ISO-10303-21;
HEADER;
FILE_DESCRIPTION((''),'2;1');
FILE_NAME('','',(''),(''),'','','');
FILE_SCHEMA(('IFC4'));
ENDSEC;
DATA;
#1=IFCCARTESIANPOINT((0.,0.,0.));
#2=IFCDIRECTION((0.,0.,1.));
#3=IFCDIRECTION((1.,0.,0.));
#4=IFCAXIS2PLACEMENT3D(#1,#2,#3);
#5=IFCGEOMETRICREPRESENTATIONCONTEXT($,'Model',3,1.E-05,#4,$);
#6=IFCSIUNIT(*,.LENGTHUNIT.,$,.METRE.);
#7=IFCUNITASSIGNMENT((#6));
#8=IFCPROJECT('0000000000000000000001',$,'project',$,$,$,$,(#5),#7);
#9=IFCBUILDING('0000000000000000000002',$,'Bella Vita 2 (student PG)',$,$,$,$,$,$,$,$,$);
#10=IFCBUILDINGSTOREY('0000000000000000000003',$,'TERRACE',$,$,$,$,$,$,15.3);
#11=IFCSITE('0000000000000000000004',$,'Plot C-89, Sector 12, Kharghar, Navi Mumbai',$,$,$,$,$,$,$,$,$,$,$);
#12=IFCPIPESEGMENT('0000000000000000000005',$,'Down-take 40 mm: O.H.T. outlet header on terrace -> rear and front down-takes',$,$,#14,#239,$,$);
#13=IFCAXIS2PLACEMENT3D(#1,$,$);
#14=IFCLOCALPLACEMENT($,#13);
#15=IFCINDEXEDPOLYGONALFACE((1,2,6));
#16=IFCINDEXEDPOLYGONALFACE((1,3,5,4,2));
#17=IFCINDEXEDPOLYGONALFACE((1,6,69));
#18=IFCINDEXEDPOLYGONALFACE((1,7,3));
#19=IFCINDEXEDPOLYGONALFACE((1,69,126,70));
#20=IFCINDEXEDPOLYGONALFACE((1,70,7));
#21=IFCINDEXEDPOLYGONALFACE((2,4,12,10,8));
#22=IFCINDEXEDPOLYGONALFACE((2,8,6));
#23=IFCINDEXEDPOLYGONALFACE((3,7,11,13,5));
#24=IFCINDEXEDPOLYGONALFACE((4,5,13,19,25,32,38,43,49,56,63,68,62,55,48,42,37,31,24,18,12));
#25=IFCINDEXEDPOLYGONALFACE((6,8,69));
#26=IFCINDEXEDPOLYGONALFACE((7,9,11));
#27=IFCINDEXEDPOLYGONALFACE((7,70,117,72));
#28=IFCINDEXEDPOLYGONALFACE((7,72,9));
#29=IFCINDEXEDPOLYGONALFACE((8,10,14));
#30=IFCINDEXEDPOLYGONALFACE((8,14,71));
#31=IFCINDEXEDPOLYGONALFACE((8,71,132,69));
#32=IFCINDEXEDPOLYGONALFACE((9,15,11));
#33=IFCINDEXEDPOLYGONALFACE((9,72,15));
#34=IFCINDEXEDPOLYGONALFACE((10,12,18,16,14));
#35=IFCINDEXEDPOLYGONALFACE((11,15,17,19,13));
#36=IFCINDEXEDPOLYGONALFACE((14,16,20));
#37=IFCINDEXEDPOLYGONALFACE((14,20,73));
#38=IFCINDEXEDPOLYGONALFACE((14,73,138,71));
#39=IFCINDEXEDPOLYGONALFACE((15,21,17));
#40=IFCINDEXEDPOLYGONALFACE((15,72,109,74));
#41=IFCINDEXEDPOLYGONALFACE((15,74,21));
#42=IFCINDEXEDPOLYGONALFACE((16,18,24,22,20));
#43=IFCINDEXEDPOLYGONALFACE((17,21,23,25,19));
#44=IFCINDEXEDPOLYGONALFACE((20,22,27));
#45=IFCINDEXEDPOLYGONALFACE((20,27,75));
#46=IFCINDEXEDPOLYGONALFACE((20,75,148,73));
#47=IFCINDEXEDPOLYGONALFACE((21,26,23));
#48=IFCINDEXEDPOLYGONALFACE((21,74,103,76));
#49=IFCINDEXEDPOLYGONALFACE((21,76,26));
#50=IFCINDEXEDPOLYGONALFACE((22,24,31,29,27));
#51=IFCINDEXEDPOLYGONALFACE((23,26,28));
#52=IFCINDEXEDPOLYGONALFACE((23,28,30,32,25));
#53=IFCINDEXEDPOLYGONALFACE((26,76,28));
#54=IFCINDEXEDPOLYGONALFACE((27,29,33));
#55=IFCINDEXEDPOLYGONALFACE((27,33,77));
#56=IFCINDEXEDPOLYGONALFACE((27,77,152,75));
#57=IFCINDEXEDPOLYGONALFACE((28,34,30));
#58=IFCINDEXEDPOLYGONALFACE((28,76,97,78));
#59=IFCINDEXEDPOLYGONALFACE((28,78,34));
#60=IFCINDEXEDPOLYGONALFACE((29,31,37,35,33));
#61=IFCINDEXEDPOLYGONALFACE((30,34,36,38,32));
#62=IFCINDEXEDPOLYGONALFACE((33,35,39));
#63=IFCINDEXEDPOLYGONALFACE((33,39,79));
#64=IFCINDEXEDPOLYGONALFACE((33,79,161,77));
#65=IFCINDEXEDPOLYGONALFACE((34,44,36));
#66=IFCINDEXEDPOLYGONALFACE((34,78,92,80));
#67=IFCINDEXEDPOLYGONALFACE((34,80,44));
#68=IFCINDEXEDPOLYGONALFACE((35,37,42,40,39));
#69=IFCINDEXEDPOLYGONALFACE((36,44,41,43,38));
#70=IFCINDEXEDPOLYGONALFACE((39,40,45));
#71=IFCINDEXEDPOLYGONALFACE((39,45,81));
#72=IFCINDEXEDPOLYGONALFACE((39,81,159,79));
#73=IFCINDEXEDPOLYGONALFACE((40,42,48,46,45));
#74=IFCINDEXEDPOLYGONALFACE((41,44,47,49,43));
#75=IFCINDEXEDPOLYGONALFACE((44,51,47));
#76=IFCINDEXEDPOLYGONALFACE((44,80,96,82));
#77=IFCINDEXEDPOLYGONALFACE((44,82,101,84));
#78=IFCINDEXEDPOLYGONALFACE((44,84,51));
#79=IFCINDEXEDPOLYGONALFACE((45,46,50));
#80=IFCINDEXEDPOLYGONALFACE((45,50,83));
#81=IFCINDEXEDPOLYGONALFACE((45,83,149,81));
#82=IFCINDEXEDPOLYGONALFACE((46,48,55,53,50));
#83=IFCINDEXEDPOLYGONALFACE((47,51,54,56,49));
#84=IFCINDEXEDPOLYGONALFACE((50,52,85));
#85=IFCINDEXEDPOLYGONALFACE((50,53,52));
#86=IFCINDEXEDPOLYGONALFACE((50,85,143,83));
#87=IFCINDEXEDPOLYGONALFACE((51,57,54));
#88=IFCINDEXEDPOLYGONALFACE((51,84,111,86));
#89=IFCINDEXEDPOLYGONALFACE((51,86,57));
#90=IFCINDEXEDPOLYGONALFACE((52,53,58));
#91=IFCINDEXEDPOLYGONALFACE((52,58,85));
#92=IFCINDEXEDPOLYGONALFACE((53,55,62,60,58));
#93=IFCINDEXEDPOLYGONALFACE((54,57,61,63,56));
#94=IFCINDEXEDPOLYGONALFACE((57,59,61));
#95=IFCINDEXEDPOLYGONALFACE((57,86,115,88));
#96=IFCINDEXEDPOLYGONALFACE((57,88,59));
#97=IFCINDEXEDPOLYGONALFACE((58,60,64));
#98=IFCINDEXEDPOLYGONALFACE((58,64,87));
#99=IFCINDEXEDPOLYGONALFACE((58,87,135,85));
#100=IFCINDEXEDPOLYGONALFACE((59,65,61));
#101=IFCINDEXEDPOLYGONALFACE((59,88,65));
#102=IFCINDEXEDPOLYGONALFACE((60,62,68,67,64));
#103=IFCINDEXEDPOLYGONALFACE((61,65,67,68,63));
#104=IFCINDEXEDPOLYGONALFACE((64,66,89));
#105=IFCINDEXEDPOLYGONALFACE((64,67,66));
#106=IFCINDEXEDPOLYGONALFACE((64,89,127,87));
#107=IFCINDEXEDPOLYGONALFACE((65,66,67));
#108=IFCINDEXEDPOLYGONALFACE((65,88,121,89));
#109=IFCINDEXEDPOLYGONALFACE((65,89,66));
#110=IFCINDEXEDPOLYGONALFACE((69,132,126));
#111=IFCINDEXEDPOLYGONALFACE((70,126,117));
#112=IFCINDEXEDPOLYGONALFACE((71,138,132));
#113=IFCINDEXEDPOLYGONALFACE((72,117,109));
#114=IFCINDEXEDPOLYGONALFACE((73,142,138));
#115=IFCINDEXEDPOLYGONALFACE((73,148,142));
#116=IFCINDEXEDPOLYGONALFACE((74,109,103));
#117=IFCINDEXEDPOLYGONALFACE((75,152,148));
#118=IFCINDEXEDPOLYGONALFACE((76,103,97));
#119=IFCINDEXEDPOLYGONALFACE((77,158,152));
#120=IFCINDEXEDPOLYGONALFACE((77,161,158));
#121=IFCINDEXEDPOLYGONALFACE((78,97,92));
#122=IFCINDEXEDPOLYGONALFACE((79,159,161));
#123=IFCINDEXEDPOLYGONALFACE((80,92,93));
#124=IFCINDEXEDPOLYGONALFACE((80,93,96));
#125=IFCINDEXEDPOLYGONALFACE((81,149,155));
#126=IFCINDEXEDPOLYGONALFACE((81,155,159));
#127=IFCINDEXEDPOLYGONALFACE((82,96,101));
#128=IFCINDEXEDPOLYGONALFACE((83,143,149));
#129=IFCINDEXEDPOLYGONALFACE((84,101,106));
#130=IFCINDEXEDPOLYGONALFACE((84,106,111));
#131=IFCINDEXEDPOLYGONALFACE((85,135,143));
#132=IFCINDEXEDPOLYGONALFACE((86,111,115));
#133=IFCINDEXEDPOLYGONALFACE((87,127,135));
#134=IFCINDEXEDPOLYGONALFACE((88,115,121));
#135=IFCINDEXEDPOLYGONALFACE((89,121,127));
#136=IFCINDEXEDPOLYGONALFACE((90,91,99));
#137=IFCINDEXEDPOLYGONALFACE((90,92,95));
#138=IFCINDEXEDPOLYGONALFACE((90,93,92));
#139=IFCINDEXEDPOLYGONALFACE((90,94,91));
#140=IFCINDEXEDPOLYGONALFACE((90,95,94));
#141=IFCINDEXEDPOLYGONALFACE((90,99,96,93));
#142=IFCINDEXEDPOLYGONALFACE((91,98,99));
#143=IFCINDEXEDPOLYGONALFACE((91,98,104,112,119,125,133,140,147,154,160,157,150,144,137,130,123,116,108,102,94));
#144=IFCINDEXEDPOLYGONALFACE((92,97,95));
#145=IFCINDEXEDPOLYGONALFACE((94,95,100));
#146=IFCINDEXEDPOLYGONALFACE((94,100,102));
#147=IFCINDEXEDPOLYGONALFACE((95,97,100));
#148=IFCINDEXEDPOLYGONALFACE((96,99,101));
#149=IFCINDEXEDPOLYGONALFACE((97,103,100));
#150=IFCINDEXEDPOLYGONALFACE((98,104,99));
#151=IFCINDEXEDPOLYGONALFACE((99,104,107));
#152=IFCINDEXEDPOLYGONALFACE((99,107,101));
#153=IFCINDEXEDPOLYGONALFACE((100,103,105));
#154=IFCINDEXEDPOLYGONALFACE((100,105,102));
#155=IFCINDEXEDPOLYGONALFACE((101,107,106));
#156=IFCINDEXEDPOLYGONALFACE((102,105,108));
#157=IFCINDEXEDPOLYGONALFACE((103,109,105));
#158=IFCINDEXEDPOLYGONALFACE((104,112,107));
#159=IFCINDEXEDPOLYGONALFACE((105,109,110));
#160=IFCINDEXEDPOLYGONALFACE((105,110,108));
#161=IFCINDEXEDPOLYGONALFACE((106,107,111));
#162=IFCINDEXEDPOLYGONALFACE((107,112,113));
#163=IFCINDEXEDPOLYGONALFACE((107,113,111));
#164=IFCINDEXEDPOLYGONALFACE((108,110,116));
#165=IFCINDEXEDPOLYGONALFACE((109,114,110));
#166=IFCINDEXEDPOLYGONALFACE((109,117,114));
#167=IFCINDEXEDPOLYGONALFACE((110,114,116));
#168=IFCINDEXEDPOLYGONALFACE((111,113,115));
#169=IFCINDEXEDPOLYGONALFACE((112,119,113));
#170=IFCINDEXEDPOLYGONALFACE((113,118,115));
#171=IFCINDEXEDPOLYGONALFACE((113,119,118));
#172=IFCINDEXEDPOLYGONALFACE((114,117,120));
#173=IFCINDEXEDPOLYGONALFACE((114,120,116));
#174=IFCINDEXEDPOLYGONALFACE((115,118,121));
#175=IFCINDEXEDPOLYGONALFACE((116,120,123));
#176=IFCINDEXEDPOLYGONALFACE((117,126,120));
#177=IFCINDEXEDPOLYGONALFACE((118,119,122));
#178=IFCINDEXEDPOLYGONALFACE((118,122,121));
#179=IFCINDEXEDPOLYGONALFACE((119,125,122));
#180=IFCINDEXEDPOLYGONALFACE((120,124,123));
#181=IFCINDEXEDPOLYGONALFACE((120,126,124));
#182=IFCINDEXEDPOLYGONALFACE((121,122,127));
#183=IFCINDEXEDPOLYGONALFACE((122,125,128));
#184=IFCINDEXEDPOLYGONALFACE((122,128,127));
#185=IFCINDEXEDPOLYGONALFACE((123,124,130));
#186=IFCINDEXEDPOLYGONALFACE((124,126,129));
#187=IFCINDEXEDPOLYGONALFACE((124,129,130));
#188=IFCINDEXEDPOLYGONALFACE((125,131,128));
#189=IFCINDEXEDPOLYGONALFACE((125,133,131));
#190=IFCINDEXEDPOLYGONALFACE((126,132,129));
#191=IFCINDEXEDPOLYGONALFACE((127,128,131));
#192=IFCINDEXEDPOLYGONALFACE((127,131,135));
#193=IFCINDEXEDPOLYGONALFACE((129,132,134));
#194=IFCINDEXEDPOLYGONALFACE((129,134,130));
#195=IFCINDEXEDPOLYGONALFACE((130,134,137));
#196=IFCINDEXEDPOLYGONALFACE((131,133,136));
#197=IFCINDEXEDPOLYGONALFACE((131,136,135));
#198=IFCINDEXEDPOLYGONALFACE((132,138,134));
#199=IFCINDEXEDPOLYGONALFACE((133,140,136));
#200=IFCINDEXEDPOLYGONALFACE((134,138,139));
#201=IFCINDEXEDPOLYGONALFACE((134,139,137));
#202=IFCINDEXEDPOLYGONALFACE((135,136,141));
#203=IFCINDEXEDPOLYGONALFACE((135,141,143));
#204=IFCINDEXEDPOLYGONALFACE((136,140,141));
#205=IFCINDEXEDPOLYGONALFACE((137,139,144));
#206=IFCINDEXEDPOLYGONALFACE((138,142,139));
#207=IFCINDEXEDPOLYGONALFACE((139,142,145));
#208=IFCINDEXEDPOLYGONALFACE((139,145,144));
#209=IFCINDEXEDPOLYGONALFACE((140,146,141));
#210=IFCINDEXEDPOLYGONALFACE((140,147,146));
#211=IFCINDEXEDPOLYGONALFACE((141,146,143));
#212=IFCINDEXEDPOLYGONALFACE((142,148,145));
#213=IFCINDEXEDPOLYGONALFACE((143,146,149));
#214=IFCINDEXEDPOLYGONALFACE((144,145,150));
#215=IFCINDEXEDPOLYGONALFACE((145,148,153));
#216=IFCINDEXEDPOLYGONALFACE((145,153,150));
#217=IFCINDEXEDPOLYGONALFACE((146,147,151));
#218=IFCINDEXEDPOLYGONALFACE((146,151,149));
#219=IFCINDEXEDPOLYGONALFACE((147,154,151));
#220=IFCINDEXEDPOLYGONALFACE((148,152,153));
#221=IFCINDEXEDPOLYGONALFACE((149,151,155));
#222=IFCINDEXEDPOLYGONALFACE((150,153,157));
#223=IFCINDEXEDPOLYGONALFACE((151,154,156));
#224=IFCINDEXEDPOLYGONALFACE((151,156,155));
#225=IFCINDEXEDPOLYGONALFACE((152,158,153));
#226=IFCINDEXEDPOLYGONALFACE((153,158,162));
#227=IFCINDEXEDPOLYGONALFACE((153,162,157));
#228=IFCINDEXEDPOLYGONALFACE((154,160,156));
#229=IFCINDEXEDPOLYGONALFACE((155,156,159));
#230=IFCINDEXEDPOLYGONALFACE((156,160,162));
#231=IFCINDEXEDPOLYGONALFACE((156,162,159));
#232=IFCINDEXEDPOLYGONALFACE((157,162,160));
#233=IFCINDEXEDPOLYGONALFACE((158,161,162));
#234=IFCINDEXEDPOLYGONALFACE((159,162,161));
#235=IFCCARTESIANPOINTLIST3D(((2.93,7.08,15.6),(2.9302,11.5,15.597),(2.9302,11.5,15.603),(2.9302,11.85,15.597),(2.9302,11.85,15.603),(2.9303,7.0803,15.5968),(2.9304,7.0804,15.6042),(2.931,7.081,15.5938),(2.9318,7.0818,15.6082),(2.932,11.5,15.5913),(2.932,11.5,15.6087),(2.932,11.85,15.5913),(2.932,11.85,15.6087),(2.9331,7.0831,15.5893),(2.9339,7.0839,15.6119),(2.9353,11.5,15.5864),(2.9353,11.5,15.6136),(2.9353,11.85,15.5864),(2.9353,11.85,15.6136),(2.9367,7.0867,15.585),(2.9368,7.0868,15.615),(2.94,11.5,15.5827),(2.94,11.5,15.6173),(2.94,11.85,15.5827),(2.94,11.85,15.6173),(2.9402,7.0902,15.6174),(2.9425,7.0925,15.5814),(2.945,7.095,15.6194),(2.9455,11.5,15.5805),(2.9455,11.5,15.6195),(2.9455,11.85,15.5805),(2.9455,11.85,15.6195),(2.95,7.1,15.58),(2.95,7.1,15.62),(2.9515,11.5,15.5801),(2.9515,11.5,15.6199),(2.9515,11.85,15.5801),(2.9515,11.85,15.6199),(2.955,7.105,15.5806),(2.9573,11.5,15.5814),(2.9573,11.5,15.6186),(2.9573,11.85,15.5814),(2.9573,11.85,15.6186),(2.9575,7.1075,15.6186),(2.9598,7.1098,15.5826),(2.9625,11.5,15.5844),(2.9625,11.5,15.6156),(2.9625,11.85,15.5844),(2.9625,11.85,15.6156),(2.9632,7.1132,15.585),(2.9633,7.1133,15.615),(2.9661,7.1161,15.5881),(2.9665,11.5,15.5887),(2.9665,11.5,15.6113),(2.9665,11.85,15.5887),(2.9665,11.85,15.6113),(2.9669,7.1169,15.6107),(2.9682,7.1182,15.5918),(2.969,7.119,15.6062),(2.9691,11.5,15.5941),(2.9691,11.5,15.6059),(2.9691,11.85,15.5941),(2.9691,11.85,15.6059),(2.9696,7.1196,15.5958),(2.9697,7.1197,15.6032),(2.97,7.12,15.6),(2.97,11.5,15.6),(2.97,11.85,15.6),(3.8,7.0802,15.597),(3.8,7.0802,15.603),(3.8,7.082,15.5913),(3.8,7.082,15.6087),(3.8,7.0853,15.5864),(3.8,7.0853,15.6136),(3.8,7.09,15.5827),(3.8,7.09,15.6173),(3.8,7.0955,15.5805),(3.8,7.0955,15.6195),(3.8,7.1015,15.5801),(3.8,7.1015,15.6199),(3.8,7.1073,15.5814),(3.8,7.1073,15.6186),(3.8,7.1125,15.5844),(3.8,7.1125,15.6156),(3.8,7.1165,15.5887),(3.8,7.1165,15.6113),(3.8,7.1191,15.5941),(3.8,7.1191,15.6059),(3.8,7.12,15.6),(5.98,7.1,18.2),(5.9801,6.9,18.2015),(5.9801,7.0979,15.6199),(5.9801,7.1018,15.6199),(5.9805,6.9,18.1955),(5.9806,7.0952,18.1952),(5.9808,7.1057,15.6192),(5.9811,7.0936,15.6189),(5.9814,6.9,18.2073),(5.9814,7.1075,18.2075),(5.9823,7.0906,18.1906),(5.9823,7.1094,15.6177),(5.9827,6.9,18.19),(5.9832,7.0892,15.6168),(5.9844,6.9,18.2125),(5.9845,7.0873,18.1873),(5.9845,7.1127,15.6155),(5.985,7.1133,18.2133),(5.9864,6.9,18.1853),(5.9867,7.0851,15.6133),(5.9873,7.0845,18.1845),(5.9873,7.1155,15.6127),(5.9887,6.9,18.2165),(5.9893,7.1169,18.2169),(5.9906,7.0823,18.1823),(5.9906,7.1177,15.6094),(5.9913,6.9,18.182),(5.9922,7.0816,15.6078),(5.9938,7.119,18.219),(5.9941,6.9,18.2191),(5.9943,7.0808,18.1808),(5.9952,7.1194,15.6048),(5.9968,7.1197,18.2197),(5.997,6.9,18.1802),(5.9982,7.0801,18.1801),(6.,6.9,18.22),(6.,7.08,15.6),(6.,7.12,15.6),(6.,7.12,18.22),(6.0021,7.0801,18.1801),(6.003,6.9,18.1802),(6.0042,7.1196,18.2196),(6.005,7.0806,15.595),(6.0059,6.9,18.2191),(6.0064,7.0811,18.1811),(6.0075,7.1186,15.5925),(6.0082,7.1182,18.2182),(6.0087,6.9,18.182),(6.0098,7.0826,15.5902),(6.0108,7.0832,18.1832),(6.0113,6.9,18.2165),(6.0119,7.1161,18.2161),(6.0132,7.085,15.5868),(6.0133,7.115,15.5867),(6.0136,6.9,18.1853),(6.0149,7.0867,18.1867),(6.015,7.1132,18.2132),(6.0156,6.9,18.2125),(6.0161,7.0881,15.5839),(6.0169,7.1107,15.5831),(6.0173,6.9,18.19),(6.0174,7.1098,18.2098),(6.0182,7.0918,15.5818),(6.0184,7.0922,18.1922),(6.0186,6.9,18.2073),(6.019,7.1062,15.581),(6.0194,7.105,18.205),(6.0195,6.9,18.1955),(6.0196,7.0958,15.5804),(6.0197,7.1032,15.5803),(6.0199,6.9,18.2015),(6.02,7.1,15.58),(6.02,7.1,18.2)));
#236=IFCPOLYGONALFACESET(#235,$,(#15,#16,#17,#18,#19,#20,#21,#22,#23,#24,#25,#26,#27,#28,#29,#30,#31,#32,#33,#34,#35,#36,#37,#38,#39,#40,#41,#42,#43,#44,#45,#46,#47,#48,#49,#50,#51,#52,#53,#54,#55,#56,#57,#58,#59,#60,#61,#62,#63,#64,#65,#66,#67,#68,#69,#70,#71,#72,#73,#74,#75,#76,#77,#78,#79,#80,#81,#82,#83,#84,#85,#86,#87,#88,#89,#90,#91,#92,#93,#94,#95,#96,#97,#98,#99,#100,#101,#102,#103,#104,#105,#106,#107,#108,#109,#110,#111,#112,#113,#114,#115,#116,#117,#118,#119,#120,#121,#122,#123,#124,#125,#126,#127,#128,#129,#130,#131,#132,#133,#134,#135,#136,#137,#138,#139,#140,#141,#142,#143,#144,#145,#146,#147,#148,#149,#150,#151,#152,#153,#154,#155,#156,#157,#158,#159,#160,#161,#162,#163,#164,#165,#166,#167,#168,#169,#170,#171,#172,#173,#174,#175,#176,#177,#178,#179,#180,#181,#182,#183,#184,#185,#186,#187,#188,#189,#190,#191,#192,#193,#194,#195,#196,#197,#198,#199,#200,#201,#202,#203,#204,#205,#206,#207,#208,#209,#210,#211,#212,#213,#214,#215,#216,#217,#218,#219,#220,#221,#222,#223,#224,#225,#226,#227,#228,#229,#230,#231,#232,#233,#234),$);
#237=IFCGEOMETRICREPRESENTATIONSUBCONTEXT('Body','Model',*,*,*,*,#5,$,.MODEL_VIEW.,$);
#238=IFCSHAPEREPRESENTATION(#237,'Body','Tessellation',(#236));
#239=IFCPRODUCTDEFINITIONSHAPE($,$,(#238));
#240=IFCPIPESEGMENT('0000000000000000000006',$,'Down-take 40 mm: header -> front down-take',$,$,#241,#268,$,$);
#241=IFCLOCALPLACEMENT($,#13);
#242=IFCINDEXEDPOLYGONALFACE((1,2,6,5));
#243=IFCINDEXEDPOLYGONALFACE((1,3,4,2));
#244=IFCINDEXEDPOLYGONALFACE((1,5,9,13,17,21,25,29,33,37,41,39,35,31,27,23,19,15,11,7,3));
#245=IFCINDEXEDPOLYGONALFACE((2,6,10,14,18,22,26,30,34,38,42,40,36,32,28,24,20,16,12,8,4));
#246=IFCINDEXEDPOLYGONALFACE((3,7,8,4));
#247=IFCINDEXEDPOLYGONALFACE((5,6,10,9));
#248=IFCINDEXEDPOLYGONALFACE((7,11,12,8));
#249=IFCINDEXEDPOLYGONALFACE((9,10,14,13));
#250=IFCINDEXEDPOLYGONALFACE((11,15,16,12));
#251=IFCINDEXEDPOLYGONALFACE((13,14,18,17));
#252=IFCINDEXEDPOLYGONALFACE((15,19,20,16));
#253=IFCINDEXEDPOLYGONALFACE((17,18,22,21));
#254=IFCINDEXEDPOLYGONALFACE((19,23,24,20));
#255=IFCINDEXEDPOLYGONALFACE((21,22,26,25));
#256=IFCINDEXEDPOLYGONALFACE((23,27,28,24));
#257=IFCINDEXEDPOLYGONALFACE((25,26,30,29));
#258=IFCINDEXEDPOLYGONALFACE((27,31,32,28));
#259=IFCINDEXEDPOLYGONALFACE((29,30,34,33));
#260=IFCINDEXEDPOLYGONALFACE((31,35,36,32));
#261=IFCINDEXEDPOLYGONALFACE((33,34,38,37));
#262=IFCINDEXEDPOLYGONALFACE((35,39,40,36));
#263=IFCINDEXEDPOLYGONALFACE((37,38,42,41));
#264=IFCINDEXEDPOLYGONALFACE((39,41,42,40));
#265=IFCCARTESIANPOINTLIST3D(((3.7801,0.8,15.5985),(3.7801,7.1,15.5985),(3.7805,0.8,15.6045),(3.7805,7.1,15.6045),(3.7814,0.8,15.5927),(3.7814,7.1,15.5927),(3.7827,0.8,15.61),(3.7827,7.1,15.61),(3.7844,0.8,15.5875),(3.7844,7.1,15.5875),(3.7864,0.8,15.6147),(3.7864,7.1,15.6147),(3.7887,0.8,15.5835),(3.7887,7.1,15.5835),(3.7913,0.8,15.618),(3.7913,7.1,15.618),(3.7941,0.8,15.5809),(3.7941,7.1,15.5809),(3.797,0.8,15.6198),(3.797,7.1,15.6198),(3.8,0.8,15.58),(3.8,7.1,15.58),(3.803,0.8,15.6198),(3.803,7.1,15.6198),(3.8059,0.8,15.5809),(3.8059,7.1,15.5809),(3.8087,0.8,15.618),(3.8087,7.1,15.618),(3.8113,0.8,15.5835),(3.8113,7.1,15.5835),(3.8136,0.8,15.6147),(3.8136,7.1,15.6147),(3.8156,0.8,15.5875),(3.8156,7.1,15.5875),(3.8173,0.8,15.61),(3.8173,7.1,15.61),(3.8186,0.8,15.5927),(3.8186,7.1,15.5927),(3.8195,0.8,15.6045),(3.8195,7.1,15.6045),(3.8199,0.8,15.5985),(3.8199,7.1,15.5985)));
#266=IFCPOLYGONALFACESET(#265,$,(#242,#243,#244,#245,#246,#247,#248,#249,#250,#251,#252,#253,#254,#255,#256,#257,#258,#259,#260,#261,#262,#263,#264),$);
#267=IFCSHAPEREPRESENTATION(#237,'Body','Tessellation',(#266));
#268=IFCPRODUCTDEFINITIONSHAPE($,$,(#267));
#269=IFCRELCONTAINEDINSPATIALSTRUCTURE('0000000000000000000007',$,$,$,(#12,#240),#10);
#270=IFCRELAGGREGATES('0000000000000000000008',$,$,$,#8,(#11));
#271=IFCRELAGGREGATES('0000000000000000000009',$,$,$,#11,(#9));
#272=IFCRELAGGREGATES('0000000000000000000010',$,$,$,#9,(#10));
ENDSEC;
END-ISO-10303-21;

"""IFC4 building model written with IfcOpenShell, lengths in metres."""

from ifc_helpers import new_model, entity, si_unit, origin, origin_with_axes, place, context, subcontext, project, spatial, element, save


model = new_model("IFC4")

# Units and contexts
model_context = context("Model", 3, precision=1e-05, world=origin_with_axes())
body_context = subcontext(model_context, "Body", "Model", "MODEL_VIEW")
ifc_project = project(units=[si_unit("LENGTHUNIT", "METRE")], contexts=[model_context])

# Site, building, storey
site = spatial("IfcSite", under=ifc_project, Name="Plot C-89, Sector 12, Kharghar, Navi Mumbai")
building = spatial("IfcBuilding", under=site, Name="Bella Vita 2 (student PG)")
storey = spatial("IfcBuildingStorey", under=building, Name="TERRACE", Elevation=15.3)

# Pipe segments
pipe_segment_1_placement = place(None, origin())
element("IfcPipeSegment", 1, at=pipe_segment_1_placement, inside=storey, Name="Down-take 40 mm: O.H.T. outlet header on terrace -> rear and front down-takes", context=body_context, shape_type="AdvancedSweptSolid", body=[
    entity("IfcSweptDiskSolid", entity("IfcPolyline", [entity("IfcCartesianPoint", [6.0, 6.9, 18.2]), entity("IfcCartesianPoint", [6.0, 7.1, 18.2]), entity("IfcCartesianPoint", [6.0, 7.1, 15.6]), entity("IfcCartesianPoint", [3.8, 7.1, 15.6]), entity("IfcCartesianPoint", [2.95, 7.1, 15.6]), entity("IfcCartesianPoint", [2.95, 11.5, 15.6]), entity("IfcCartesianPoint", [2.95, 11.85, 15.6])]), 0.02),
])
pipe_segment_2_placement = place(None, origin())
element("IfcPipeSegment", 2, at=pipe_segment_2_placement, inside=storey, Name="Down-take 40 mm: header -> front down-take", context=body_context, shape_type="AdvancedSweptSolid", body=[
    entity("IfcSweptDiskSolid", entity("IfcPolyline", [entity("IfcCartesianPoint", [3.8, 7.1, 15.6]), entity("IfcCartesianPoint", [3.8, 0.8, 15.6])]), 0.02),
])

save(model, "model.ifc")
